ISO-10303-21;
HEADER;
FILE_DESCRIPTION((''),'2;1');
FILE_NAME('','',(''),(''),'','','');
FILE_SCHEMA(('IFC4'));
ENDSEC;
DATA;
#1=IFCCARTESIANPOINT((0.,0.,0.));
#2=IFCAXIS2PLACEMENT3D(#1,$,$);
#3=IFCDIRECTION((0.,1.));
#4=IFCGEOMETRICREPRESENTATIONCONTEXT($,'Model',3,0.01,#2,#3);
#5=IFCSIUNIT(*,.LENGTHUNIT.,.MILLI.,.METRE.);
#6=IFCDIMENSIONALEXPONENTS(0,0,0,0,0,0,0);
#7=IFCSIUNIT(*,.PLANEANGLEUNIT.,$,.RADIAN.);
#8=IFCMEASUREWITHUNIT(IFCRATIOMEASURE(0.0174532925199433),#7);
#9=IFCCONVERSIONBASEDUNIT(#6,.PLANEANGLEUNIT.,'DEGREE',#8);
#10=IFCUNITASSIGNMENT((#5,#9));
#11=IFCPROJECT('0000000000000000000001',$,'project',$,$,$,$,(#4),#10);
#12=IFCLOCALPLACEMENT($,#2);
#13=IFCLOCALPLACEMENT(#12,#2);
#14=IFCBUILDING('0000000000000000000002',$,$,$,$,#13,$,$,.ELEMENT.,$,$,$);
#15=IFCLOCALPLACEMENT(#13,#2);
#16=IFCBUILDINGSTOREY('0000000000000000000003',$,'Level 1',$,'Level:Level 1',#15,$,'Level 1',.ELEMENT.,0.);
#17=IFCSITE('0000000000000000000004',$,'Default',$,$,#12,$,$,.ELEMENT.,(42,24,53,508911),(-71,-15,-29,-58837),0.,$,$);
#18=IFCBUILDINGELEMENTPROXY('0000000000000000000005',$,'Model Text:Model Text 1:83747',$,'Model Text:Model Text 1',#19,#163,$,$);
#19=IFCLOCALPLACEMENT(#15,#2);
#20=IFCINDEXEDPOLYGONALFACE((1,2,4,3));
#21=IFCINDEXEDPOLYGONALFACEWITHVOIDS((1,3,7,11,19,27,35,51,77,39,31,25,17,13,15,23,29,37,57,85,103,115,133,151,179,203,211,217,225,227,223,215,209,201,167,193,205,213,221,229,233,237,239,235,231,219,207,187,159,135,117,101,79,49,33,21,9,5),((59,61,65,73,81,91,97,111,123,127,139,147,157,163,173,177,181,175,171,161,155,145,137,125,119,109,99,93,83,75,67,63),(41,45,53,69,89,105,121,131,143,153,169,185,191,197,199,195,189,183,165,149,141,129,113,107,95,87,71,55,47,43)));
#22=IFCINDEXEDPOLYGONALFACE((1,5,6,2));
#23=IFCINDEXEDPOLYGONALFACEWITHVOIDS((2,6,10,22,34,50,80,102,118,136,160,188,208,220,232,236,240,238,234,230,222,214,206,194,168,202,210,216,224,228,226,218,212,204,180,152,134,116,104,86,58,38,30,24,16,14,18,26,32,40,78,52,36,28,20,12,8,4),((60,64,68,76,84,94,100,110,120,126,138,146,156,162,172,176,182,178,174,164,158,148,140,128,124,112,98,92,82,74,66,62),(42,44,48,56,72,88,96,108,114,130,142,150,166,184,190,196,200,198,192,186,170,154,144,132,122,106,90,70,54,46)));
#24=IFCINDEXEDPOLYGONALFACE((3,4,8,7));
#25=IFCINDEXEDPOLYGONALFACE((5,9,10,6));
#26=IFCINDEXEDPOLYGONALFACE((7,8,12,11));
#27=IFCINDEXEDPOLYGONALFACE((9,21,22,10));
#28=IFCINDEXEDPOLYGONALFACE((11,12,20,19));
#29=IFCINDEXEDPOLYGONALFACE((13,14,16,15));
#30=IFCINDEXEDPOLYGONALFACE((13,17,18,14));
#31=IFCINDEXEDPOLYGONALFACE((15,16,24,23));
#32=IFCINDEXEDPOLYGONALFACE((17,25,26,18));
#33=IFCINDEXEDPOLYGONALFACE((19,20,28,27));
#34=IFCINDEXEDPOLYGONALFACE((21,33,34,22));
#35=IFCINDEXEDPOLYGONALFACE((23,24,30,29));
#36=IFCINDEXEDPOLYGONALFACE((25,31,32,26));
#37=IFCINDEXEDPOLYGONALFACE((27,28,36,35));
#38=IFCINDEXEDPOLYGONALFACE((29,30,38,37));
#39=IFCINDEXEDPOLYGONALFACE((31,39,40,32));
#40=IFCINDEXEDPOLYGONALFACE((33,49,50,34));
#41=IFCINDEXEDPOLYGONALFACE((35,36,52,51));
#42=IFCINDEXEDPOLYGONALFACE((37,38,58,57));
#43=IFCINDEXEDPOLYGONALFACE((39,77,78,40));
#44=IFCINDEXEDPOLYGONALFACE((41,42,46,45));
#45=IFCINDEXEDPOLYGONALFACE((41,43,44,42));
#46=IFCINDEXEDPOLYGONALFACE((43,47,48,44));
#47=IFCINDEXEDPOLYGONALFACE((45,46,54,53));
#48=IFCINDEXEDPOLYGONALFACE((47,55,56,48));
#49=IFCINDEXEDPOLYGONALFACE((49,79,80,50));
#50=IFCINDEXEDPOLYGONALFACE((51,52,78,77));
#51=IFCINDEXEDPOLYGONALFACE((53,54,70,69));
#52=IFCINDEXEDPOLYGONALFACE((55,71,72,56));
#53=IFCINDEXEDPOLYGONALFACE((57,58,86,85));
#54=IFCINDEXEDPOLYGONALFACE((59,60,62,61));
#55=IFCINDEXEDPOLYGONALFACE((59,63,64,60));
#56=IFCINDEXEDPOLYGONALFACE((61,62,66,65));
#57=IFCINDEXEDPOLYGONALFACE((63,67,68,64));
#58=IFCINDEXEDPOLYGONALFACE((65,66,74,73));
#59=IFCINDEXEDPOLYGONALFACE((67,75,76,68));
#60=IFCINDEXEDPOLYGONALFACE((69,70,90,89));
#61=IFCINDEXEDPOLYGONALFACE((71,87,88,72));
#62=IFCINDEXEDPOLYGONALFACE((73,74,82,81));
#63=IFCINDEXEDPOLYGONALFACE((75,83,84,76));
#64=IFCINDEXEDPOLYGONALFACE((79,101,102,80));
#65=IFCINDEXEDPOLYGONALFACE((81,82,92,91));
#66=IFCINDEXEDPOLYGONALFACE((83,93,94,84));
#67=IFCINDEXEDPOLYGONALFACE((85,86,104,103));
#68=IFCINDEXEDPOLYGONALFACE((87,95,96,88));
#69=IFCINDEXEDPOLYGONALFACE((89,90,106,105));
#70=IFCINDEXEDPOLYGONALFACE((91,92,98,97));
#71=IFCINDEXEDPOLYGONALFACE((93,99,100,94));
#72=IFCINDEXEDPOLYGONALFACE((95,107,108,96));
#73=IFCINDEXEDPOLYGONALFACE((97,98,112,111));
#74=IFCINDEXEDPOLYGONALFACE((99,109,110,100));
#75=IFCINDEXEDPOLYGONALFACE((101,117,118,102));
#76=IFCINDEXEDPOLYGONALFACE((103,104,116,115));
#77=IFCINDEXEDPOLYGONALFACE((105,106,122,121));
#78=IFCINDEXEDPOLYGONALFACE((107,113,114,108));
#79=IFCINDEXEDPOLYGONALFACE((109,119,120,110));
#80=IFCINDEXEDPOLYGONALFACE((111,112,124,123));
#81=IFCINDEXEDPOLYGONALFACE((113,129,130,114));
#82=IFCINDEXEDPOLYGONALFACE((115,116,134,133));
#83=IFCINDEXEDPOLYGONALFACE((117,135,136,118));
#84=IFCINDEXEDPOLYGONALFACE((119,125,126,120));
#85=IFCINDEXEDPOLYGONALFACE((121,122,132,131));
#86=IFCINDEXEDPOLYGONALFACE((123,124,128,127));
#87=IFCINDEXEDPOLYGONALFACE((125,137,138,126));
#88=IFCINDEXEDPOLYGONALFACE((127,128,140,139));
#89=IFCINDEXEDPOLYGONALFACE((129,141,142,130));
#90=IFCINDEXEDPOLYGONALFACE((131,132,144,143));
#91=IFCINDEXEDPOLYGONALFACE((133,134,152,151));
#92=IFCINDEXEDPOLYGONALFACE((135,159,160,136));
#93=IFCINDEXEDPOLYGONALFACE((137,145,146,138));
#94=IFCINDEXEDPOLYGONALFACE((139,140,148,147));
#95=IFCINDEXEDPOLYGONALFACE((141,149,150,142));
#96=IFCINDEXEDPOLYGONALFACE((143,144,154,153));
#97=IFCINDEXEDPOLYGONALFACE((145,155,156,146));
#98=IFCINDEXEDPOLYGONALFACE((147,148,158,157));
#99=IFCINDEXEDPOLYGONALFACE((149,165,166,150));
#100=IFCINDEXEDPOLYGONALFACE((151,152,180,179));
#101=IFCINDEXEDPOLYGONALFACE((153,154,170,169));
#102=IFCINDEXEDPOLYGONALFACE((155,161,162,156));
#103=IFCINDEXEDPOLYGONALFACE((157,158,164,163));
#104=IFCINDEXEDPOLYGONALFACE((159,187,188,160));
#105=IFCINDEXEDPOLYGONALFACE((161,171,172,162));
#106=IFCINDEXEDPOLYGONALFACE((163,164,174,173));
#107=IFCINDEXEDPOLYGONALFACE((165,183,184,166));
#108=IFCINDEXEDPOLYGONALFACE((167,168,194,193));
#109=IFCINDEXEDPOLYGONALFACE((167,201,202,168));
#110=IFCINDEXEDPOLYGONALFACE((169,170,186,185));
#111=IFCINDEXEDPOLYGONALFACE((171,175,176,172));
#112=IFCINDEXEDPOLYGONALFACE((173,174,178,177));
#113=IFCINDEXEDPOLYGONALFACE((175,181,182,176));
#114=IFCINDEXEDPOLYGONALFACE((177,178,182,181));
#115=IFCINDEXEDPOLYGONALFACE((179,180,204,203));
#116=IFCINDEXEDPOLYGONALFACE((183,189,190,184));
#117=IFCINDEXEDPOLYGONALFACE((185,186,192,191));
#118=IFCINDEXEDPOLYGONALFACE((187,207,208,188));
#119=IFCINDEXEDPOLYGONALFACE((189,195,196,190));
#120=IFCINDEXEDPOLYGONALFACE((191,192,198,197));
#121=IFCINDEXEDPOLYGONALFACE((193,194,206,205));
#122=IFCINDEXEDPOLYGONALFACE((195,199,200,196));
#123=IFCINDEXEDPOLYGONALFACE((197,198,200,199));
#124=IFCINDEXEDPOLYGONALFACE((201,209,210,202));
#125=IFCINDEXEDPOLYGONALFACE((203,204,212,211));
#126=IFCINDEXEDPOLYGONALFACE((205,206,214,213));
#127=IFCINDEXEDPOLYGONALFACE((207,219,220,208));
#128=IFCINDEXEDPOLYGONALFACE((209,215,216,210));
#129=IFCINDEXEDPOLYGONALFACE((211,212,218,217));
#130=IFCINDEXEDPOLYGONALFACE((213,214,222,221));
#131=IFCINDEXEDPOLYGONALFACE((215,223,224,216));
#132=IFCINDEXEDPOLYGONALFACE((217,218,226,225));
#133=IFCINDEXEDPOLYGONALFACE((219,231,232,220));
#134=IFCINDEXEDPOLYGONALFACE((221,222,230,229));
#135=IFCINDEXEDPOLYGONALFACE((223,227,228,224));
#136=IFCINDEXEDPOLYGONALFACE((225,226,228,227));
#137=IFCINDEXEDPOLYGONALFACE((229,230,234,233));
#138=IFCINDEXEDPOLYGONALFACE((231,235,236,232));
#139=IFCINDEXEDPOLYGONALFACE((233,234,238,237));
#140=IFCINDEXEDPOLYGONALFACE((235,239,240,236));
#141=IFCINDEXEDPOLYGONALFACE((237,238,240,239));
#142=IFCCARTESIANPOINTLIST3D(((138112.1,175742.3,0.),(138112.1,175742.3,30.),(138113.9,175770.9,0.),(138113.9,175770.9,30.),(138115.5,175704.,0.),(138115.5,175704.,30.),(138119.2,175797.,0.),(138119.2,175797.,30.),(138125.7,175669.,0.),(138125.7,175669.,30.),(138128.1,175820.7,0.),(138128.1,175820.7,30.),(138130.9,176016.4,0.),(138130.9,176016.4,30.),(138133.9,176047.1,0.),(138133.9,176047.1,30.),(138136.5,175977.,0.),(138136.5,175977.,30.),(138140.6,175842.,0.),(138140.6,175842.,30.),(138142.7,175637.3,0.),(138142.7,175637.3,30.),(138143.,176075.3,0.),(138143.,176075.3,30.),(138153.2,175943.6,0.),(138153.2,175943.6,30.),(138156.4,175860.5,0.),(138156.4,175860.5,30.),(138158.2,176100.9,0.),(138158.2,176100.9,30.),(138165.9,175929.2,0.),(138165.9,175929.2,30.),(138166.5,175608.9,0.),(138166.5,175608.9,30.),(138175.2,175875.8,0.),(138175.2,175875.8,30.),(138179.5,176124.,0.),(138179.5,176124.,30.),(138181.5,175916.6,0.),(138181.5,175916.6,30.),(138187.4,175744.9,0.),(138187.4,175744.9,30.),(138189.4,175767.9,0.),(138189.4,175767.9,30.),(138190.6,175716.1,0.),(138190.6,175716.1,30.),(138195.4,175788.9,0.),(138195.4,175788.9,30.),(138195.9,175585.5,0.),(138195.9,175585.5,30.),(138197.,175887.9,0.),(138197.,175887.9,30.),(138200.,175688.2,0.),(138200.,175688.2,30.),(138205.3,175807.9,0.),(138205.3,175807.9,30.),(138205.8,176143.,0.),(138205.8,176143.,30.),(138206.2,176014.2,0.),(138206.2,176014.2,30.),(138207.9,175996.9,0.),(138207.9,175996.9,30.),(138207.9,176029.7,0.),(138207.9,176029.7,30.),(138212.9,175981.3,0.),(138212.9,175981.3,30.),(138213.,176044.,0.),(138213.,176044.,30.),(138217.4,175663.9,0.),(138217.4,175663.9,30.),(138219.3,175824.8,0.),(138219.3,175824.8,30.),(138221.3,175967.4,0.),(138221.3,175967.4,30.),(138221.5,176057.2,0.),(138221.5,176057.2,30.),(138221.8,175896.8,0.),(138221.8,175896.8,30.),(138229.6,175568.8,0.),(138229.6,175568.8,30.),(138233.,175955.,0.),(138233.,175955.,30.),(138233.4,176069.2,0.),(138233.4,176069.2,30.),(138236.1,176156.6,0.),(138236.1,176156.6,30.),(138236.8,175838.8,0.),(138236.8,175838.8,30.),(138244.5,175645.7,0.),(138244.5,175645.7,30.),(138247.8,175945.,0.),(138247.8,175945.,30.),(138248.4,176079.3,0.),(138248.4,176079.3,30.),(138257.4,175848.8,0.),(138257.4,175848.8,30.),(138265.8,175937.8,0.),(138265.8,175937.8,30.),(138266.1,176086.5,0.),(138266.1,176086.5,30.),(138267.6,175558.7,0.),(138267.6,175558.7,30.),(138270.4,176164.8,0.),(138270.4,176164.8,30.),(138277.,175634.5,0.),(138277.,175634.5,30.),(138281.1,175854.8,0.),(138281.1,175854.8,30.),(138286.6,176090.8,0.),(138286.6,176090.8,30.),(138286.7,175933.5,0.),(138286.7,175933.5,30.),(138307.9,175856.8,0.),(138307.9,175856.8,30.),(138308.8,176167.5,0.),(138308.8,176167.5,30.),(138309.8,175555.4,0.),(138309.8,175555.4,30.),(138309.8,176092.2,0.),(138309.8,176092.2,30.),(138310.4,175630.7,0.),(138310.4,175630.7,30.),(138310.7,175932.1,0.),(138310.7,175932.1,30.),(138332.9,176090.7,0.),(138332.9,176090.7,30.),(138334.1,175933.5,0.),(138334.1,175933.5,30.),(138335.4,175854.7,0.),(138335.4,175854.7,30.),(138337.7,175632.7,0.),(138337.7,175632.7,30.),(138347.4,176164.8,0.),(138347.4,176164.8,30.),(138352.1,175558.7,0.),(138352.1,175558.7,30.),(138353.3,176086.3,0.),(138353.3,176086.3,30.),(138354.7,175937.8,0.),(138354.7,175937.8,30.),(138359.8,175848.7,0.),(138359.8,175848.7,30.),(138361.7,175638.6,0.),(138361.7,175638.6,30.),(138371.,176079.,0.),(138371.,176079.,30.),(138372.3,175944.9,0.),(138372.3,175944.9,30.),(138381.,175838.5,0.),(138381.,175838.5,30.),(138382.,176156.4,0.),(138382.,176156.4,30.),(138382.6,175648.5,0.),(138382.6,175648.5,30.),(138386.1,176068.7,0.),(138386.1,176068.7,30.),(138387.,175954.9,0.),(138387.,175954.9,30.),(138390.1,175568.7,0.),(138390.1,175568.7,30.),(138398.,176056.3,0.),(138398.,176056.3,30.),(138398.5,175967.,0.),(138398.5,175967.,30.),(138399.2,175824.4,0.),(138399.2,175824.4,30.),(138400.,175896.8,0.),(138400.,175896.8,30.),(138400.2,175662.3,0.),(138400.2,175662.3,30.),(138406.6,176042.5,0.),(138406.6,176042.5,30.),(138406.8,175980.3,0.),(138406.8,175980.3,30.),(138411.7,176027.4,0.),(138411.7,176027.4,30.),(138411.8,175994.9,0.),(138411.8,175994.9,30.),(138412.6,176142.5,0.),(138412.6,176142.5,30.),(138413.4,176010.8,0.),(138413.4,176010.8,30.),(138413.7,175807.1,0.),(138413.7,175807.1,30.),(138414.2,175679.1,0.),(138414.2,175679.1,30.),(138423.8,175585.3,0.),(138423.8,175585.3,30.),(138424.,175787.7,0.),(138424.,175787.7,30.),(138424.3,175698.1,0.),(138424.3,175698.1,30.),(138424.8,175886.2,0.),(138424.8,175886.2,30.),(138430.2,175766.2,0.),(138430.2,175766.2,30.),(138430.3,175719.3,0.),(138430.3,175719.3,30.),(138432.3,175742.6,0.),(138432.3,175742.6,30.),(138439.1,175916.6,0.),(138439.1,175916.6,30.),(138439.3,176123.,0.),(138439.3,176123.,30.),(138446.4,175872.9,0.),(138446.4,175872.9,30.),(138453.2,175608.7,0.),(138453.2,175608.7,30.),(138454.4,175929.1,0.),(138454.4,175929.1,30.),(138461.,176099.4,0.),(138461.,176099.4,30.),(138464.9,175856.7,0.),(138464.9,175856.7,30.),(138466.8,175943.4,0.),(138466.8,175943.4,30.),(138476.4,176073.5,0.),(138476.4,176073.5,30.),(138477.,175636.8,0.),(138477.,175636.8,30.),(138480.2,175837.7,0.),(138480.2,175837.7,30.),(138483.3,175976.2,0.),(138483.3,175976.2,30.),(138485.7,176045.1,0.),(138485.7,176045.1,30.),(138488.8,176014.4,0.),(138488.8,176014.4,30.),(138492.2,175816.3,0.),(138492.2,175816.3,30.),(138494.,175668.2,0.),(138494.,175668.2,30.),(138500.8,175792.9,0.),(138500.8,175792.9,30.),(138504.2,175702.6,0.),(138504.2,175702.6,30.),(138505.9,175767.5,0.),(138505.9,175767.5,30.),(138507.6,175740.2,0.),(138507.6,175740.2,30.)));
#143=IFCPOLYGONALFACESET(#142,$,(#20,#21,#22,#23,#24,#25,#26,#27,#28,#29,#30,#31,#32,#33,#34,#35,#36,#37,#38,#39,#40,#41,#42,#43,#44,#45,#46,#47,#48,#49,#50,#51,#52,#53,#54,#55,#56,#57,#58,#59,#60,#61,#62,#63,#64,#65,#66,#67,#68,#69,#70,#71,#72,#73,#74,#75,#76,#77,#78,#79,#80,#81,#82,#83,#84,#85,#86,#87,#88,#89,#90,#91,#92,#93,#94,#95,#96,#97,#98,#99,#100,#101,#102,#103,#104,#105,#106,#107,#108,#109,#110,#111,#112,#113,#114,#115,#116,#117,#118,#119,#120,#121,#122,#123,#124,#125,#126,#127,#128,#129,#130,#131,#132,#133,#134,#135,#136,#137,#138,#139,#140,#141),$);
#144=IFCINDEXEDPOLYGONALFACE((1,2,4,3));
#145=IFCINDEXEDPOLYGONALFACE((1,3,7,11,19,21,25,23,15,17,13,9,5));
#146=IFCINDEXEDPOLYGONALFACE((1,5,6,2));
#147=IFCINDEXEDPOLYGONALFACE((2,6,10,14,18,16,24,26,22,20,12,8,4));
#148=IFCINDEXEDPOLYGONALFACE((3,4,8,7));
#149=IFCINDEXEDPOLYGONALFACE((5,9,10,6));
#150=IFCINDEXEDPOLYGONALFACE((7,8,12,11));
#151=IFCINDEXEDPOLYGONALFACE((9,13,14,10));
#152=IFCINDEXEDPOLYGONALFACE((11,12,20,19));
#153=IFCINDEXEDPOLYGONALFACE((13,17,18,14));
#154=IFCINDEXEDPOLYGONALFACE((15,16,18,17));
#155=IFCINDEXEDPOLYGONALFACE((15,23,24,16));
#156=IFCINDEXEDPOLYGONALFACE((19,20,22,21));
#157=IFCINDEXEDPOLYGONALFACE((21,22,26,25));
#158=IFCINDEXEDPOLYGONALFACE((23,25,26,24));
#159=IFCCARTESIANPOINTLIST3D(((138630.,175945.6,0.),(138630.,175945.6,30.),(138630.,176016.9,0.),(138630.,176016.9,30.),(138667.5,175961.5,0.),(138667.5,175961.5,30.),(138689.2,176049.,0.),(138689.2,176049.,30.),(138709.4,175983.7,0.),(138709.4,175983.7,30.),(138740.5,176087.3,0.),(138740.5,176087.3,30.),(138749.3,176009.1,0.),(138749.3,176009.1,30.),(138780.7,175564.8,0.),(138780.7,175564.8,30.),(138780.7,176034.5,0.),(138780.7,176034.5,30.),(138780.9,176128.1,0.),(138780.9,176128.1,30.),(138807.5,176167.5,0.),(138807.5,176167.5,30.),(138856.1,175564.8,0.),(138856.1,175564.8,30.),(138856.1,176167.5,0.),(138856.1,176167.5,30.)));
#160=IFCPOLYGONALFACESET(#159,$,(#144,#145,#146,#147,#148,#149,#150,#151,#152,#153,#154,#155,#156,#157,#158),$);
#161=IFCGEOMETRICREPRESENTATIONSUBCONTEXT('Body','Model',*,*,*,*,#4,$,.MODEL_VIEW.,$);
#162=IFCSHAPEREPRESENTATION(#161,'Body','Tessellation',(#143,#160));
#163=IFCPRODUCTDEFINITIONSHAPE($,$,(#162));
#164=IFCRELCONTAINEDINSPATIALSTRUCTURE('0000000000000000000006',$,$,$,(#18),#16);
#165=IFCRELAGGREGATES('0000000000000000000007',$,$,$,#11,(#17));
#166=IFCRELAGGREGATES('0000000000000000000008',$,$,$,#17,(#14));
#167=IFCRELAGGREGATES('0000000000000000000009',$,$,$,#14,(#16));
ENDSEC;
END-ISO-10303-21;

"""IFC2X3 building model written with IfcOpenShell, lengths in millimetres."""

from ifc_helpers import new_model, entity, si_unit, converted_unit, direction, frame, origin, place, context, subcontext, project, spatial, polyline, outline, extrude, element, save


model = new_model("IFC2X3")

# Units and contexts
model_context = context("Model", 3, precision=0.01, world=origin(), true_north=direction((0.0, 1.0)))
body_context = subcontext(model_context, "Body", "Model", "MODEL_VIEW")
ifc_project = project(units=[si_unit("LENGTHUNIT", "METRE", prefix="MILLI"), converted_unit("PLANEANGLEUNIT", "DEGREE", entity("IfcRatioMeasure", 0.0174532925199433), si_unit("PLANEANGLEUNIT", "RADIAN"), dimensions=[0, 0, 0, 0, 0, 0, 0])], contexts=[model_context])

# Site, building, storey
site_placement = place(None, origin())
site = spatial("IfcSite", under=ifc_project, at=site_placement, Name="Default", CompositionType="ELEMENT", RefLatitude=(42, 24, 53, 508911), RefLongitude=(-71, -15, -29, -58837), RefElevation=0.0)
building_placement = place(site_placement, origin())
building = spatial("IfcBuilding", under=site, at=building_placement, CompositionType="ELEMENT")
storey_placement = place(building_placement, origin())
storey = spatial("IfcBuildingStorey", under=building, at=storey_placement, Name="Level 1", ObjectType="Level:Level 1", LongName="Level 1", CompositionType="ELEMENT", Elevation=0.0)

# Building element proxy
proxy_1_placement = place(storey_placement, origin())
element("IfcBuildingElementProxy", 1, at=proxy_1_placement, inside=storey, Name="Model Text:Model Text 1:83747", ObjectType="Model Text:Model Text 1", context=body_context, shape_type="SweptSolid", body=[
    extrude(outline(polyline([(74.3, -53.8), (100.6, -53.8), (125.3, -49.8), (148.1, -41.8), (169.2, -29.7), (188.1, -13.8), (204.5, 5.5), (218.4, 28.3), (229.7, 54.7), (239.4, 91.9), (241.6, 128.3), (236.2, 163.8), (223.4, 198.6), (203.6, 230.5), (177.5, 257.6), (145.1, 279.9), (106.4, 297.2), (65.5, 308.4), (26.4, 311.7), (-11.0, 307.4), (-46.5, 295.4), (-78.4, 276.8), (-105.0, 253.1), (-126.2, 224.1), (-142.0, 189.8), (-149.6, 163.5), (-153.3, 137.9), (-153.1, 113.0), (-149.0, 88.8), (-141.0, 65.8), (-129.1, 44.3), (-113.3, 24.5), (-93.5, 6.2), (-137.0, 0.7), (-155.5, -5.9), (-172.0, -15.2), (-198.6, -40.6), (-216.7, -74.6), (-224.1, -104.7), (-225.0, -134.5), (-219.1, -164.1), (-206.7, -193.5), (-188.1, -220.9), (-164.0, -244.3), (-134.2, -263.9), (-98.8, -279.5), (-61.8, -289.8), (-26.7, -293.7), (6.5, -291.1), (37.6, -282.0), (65.4, -267.5), (88.3, -248.5), (106.4, -225.0), (119.6, -197.1), (127.6, -158.1), (123.1, -121.0), (116.1, -103.3), (105.6, -86.1), (74.3, -53.8)]), holes=[polyline([(49.4, -169.7), (42.6, -183.7), (33.0, -195.4), (20.5, -205.0), (5.3, -212.3), (-12.2, -216.7), (-31.3, -217.5), (-52.0, -214.7), (-74.4, -208.2), (-95.6, -199.0), (-113.4, -188.0), (-127.6, -175.1), (-138.3, -160.4), (-145.4, -144.7), (-148.8, -128.8), (-148.5, -112.8), (-144.5, -96.7), (-137.6, -82.3), (-128.0, -70.2), (-115.7, -60.4), (-100.8, -52.9), (-83.6, -48.5), (-64.6, -47.7), (-43.8, -50.6), (-21.3, -57.2), (0.8, -66.6), (19.1, -77.7), (33.6, -90.5), (44.2, -105.0), (51.0, -120.5), (54.2, -136.4), (53.7, -152.8), (49.4, -169.7)]), polyline([(157.9, 77.5), (148.2, 56.6), (135.5, 38.8), (119.8, 24.3), (100.9, 13.0), (79.8, 5.8), (57.0, 3.3), (32.7, 5.7), (6.7, 12.8), (-18.5, 24.0), (-39.4, 37.9), (-56.0, 54.6), (-68.3, 74.1), (-76.1, 95.2), (-79.3, 116.9), (-77.9, 139.3), (-71.9, 162.2), (-62.2, 183.5), (-49.4, 201.4), (-33.6, 215.9), (-14.7, 227.0), (6.6, 234.1), (29.5, 236.4), (54.2, 233.8), (80.5, 226.5), (110.7, 211.7), (137.5, 190.2), (156.9, 164.0), (165.1, 135.2), (164.6, 105.7), (157.9, 77.5)])]), frame((138309.9, 175871.1, 0.0), z_axis=(0.0, 0.0, 1.0), x_axis=(-0.941552, -0.336867, 0.0)), (0.0, 0.0, 1.0), 30.0),
    extrude(outline(polyline([(-410.6, -111.6), (192.1, -111.6), (192.1, -63.1), (152.7, -36.4), (111.9, 4.0), (73.6, 55.2), (41.4, 114.4), (-29.8, 114.4), (-13.9, 77.0), (8.3, 35.1), (33.7, -4.8), (59.1, -36.3), (-410.6, -36.3), (-410.6, -111.6)])), frame((138744.5, 175975.4, 0.0), z_axis=(0.0, 0.0, 1.0), x_axis=(0.0, 1.0, 0.0)), (0.0, 0.0, 1.0), 30.0),
])

save(model, "model.ifc")
